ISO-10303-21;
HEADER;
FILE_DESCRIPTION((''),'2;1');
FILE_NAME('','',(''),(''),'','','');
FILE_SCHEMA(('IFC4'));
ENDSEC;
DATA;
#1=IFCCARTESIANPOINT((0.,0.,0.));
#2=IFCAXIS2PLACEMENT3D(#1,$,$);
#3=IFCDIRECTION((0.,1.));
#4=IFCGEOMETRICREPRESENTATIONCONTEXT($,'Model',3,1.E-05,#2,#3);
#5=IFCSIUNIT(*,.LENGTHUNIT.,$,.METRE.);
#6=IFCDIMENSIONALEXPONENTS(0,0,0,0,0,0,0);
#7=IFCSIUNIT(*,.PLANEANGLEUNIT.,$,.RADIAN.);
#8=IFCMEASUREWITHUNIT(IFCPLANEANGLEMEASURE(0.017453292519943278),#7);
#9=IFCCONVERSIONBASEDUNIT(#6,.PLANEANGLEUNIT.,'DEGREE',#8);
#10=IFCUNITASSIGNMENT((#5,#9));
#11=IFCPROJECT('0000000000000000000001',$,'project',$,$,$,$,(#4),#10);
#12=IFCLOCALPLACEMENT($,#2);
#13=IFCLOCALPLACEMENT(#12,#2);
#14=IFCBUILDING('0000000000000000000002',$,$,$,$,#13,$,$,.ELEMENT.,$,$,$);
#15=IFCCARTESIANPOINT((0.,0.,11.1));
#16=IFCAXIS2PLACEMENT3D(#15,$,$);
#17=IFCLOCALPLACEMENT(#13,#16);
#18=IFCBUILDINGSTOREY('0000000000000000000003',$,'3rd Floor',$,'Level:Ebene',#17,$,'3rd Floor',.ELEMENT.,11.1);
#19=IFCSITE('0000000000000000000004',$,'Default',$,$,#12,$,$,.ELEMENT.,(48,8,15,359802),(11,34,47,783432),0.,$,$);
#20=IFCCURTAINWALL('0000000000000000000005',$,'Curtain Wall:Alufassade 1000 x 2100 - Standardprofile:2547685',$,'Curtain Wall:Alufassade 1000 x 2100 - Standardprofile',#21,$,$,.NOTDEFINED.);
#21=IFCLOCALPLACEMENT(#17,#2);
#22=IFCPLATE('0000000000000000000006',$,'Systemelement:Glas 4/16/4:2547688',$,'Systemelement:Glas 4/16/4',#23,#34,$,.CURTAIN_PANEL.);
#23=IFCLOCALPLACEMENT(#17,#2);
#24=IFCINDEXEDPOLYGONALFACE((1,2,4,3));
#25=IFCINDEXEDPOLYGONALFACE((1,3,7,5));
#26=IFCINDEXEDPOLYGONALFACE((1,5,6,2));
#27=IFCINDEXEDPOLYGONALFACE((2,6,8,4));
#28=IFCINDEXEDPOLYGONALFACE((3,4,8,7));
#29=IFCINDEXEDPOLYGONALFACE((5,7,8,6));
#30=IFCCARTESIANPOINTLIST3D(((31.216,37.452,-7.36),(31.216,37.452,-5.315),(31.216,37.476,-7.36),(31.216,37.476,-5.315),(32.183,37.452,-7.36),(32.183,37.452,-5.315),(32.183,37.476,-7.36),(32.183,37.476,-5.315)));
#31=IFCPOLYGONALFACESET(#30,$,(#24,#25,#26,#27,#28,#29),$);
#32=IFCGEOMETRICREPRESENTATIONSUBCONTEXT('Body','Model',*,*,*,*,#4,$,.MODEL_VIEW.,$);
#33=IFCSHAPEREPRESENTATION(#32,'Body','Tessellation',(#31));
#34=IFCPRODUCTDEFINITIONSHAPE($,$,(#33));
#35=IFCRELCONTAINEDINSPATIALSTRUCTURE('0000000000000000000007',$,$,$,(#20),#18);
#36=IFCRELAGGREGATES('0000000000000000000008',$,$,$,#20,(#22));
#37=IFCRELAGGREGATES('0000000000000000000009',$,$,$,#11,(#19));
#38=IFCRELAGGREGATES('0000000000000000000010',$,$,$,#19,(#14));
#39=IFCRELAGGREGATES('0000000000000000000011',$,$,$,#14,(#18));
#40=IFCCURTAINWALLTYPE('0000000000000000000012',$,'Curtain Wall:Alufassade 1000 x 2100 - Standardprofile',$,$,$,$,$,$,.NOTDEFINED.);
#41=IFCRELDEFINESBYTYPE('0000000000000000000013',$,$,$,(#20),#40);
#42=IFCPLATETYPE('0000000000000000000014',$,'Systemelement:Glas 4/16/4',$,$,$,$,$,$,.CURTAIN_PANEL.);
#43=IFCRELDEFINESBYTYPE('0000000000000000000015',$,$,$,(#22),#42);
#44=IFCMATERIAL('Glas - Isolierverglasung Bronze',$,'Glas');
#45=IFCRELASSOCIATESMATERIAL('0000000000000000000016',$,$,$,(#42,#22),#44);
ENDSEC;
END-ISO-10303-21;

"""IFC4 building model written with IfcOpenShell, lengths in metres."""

from ifc_helpers import new_model, entity, si_unit, converted_unit, direction, frame, origin, place, context, subcontext, project, spatial, indexed_curve, outline, extrude, source, transform, mapped, material, type_object, type_shapes, element, aggregate, save


model = new_model("IFC4")

# Units and contexts
model_context = context("Model", 3, precision=1e-05, world=origin(), true_north=direction((0.0, 1.0)))
body_context = subcontext(model_context, "Body", "Model", "MODEL_VIEW")
ifc_project = project(units=[si_unit("LENGTHUNIT", "METRE"), converted_unit("PLANEANGLEUNIT", "DEGREE", entity("IfcPlaneAngleMeasure", 0.017453292519943278), si_unit("PLANEANGLEUNIT", "RADIAN"), dimensions=[0, 0, 0, 0, 0, 0, 0])], contexts=[model_context])

# Site, building, storey
site_placement = place(None, origin())
site = spatial("IfcSite", under=ifc_project, at=site_placement, Name="Default", CompositionType="ELEMENT", RefLatitude=(48, 8, 15, 359802), RefLongitude=(11, 34, 47, 783432), RefElevation=0.0)
building_placement = place(site_placement, origin())
building = spatial("IfcBuilding", under=site, at=building_placement, CompositionType="ELEMENT")
storey_placement = place(building_placement, frame((0.0, 0.0, 11.1)))
storey = spatial("IfcBuildingStorey", under=building, at=storey_placement, Name="3rd Floor", ObjectType="Level:Ebene", LongName="3rd Floor", CompositionType="ELEMENT", Elevation=11.1)

# Shared definitions
curtain_wall_type = type_object("IfcCurtainWallType", Name="Curtain Wall:Alufassade 1000 x 2100 - Standardprofile", PredefinedType="NOTDEFINED")

# Curtain wall
curtain_wall_1_placement = place(storey_placement, frame((0.0, 0.0, -11.1)))
curtain_wall_1 = element("IfcCurtainWall", 1, at=curtain_wall_1_placement, inside=storey, type_object=curtain_wall_type, Name="Curtain Wall:Alufassade 1000 x 2100 - Standardprofile:2547685", ObjectType="Curtain Wall:Alufassade 1000 x 2100 - Standardprofile", PredefinedType="NOTDEFINED")

# Plate
ifc_material_1 = material(Name="Glas - Isolierverglasung Bronze", Category="Glas")
plate_type_1 = type_object("IfcPlateType", Name="Systemelement:Glas 4/16/4", PredefinedType="CURTAIN_PANEL", material=ifc_material_1)
shared_shape_1 = source(origin(), body_context, "Body", "SweptSolid", [
    extrude(outline(indexed_curve([(-0.012, -0.4835), (0.012, -0.4835), (0.012, 0.4835), (-0.012, 0.4835), (-0.012, -0.4835)], self_intersect=False)), frame((0.0, 0.0, 0.0), z_axis=(0.0, 0.0, 1.0), x_axis=(0.0, 1.0, 0.0)), (0.0, 0.0, 1.0), 2.045),
])
type_shapes(plate_type_1, [shared_shape_1])
plate_1_placement = place(curtain_wall_1_placement, frame((31.6995, 37.464, 3.74), z_axis=(0.0, 0.0, 1.0), x_axis=(-1.0, 0.0, 0.0)))
plate_1 = element("IfcPlate", 2, at=plate_1_placement, type_object=plate_type_1, material=ifc_material_1, Name="Systemelement:Glas 4/16/4:2547688", ObjectType="Systemelement:Glas 4/16/4", PredefinedType="CURTAIN_PANEL", context=body_context, shape_type="MappedRepresentation", body=[
    mapped(shared_shape_1, transform((0.0, 0.0, 0.0), scale=1.0)),
])
aggregate(curtain_wall_1, [plate_1])

save(model, "model.ifc")
